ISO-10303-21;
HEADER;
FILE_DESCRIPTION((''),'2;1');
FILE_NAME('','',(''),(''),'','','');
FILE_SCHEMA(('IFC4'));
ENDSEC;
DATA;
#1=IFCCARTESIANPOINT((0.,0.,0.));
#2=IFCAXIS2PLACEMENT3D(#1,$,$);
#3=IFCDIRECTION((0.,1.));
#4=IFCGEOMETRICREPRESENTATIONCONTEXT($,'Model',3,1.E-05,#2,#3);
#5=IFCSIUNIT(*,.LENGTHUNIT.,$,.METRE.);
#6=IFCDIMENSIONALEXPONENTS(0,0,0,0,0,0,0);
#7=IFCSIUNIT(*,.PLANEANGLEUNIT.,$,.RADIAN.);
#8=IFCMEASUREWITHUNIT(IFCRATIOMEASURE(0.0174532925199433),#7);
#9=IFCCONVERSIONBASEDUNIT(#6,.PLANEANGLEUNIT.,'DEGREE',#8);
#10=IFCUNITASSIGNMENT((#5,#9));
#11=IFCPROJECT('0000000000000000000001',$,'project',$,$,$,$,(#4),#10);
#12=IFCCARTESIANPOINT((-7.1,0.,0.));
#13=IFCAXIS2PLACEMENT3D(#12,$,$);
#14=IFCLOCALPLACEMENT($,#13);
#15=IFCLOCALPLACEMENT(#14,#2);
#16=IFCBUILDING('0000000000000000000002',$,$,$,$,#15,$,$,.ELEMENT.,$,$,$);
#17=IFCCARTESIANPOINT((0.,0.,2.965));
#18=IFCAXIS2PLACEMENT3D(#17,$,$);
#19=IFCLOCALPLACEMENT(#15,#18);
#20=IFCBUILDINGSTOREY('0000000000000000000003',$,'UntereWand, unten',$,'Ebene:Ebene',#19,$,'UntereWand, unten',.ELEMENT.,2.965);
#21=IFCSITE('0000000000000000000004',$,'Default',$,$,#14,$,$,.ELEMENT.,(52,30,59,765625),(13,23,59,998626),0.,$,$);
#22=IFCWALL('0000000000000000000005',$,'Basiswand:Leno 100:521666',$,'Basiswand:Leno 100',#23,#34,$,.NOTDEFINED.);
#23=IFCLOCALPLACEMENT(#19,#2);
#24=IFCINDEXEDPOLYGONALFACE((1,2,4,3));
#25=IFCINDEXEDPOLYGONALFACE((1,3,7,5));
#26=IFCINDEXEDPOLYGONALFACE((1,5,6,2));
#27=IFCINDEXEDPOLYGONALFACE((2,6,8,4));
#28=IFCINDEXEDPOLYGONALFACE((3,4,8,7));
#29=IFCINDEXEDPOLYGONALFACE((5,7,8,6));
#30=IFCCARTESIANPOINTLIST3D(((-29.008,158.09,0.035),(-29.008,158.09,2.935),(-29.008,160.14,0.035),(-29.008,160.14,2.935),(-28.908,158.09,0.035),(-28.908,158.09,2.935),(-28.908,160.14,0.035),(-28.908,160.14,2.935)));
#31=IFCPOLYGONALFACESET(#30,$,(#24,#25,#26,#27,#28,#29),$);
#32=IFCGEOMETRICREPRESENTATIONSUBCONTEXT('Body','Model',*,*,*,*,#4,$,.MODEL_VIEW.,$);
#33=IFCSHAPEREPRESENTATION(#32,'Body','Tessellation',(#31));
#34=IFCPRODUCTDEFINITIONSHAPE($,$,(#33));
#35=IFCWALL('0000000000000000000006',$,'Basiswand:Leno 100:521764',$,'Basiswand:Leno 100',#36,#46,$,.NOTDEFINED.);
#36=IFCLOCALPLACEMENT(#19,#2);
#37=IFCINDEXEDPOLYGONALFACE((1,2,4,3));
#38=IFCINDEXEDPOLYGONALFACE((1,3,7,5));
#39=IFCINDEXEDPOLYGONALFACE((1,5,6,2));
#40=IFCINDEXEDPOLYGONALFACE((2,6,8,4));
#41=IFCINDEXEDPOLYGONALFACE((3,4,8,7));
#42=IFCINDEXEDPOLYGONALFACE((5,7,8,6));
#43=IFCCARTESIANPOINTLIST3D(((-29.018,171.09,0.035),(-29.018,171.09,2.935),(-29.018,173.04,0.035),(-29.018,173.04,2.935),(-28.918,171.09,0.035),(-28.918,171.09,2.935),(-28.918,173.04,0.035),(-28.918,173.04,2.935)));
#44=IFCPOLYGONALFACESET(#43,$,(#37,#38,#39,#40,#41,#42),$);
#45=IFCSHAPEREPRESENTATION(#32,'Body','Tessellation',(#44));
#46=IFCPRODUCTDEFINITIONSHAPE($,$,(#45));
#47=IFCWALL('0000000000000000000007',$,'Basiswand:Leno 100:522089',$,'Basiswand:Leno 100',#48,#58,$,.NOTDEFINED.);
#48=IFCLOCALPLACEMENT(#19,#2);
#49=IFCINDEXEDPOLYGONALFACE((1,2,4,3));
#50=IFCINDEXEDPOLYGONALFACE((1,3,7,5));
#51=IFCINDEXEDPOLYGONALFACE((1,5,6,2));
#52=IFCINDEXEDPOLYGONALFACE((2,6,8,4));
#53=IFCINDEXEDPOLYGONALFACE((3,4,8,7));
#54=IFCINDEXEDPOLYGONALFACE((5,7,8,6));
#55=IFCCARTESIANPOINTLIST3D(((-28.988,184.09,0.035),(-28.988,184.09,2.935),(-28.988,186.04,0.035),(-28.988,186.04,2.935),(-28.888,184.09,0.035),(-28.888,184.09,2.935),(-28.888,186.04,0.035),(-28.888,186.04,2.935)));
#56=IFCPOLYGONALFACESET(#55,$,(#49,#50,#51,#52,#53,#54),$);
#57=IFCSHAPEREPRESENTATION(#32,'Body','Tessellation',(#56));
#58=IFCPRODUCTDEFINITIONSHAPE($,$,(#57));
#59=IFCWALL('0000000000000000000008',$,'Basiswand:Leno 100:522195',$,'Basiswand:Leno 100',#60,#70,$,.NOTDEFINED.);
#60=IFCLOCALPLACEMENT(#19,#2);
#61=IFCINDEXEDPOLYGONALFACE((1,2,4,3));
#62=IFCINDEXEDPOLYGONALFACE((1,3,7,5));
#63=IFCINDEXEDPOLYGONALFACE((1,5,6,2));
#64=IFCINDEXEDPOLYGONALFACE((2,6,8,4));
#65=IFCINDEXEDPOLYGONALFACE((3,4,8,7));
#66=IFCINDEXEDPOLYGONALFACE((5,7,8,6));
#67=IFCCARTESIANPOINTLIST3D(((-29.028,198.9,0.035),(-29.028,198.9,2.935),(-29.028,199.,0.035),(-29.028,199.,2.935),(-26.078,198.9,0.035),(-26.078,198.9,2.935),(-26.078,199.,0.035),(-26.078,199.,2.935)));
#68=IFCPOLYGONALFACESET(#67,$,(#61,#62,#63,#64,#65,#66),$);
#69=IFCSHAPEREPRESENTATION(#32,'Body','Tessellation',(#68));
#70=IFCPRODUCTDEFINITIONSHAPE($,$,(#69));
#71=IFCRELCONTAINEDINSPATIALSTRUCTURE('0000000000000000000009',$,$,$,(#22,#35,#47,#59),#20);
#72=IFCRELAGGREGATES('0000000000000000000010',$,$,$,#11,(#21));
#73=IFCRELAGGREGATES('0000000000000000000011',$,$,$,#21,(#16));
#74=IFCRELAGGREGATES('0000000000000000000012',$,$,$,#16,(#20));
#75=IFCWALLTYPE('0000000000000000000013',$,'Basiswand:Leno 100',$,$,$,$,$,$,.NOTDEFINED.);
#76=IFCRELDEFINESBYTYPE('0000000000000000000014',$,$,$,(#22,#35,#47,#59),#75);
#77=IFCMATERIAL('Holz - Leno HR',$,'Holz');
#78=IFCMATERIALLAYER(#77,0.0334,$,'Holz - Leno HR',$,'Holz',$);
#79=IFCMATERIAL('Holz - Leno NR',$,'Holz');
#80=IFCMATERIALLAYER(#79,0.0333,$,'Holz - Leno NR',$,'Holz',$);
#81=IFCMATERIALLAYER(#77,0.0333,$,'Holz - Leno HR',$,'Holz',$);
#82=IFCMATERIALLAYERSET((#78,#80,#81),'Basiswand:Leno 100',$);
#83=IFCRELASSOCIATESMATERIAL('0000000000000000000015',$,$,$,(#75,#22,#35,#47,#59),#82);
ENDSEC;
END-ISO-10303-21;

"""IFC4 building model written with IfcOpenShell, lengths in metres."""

from ifc_helpers import new_model, entity, si_unit, converted_unit, direction, frame, origin, place, context, subcontext, project, spatial, indexed_curve, outline, extrude, material, layer, layer_set, type_object, element, save


model = new_model("IFC4")

# Units and contexts
model_context = context("Model", 3, precision=1e-05, world=origin(), true_north=direction((0.0, 1.0)))
body_context = subcontext(model_context, "Body", "Model", "MODEL_VIEW")
ifc_project = project(units=[si_unit("LENGTHUNIT", "METRE"), converted_unit("PLANEANGLEUNIT", "DEGREE", entity("IfcRatioMeasure", 0.0174532925199433), si_unit("PLANEANGLEUNIT", "RADIAN"), dimensions=[0, 0, 0, 0, 0, 0, 0])], contexts=[model_context])

# Site, building, storey
site_placement = place(None, frame((-7.1, 0.0, 0.0)))
site = spatial("IfcSite", under=ifc_project, at=site_placement, Name="Default", CompositionType="ELEMENT", RefLatitude=(52, 30, 59, 765625), RefLongitude=(13, 23, 59, 998626), RefElevation=0.0)
building_placement = place(site_placement, origin())
building = spatial("IfcBuilding", under=site, at=building_placement, CompositionType="ELEMENT")
storey_placement = place(building_placement, frame((0.0, 0.0, 2.965)))
storey = spatial("IfcBuildingStorey", under=building, at=storey_placement, Name="UntereWand, unten", ObjectType="Ebene:Ebene", LongName="UntereWand, unten", CompositionType="ELEMENT", Elevation=2.965)

# Shared definitions
ifc_material_1 = material(Name="Holz - Leno HR", Category="Holz")
ifc_layer_1 = layer(ifc_material_1, 0.0334, Name="Holz - Leno HR", Category="Holz")
ifc_material_2 = material(Name="Holz - Leno NR", Category="Holz")
ifc_layer_2 = layer(ifc_material_2, 0.0333, Name="Holz - Leno NR", Category="Holz")
ifc_layer_3 = layer(ifc_material_1, 0.0333, Name="Holz - Leno HR", Category="Holz")
ifc_layer_set = layer_set([ifc_layer_1, ifc_layer_2, ifc_layer_3], Name="Basiswand:Leno 100")
wall_type = type_object("IfcWallType", Name="Basiswand:Leno 100", PredefinedType="NOTDEFINED", material=ifc_layer_set)

# Walls
wall_1_placement = place(storey_placement, frame((-28.958, 158.09, 0.035), z_axis=(0.0, 0.0, 1.0), x_axis=(0.0, 1.0, 0.0)))
element("IfcWall", 1, at=wall_1_placement, inside=storey, type_object=wall_type, material=ifc_layer_set, Name="Basiswand:Leno 100:521666", ObjectType="Basiswand:Leno 100", PredefinedType="NOTDEFINED", context=body_context, shape_type="SweptSolid", body=[
    extrude(outline(indexed_curve([(2.05, 0.05), (0.0, 0.05), (0.0, -0.05), (2.05, -0.05), (2.05, 0.05)], self_intersect=False)), origin(), (0.0, 0.0, 1.0), 2.9),
])
wall_2_placement = place(storey_placement, frame((-28.968, 171.09, 0.035), z_axis=(0.0, 0.0, 1.0), x_axis=(0.0, 1.0, 0.0)))
element("IfcWall", 2, at=wall_2_placement, inside=storey, type_object=wall_type, material=ifc_layer_set, Name="Basiswand:Leno 100:521764", ObjectType="Basiswand:Leno 100", PredefinedType="NOTDEFINED", context=body_context, shape_type="SweptSolid", body=[
    extrude(outline(indexed_curve([(1.95, 0.05), (0.0, 0.05), (0.0, -0.05), (1.95, -0.05), (1.95, 0.05)], self_intersect=False)), origin(), (0.0, 0.0, 1.0), 2.9),
])
wall_3_placement = place(storey_placement, frame((-28.938, 184.09, 0.035), z_axis=(0.0, 0.0, 1.0), x_axis=(0.0, 1.0, 0.0)))
element("IfcWall", 3, at=wall_3_placement, inside=storey, type_object=wall_type, material=ifc_layer_set, Name="Basiswand:Leno 100:522089", ObjectType="Basiswand:Leno 100", PredefinedType="NOTDEFINED", context=body_context, shape_type="SweptSolid", body=[
    extrude(outline(indexed_curve([(1.95, 0.05), (0.0, 0.05), (0.0, -0.05), (1.95, -0.05), (1.95, 0.05)], self_intersect=False)), origin(), (0.0, 0.0, 1.0), 2.9),
])
wall_4_placement = place(storey_placement, frame((-26.078, 198.95, 0.035), z_axis=(0.0, 0.0, 1.0), x_axis=(-1.0, 0.0, 0.0)))
element("IfcWall", 4, at=wall_4_placement, inside=storey, type_object=wall_type, material=ifc_layer_set, Name="Basiswand:Leno 100:522195", ObjectType="Basiswand:Leno 100", PredefinedType="NOTDEFINED", context=body_context, shape_type="SweptSolid", body=[
    extrude(outline(indexed_curve([(2.95, 0.05), (0.0, 0.05), (0.0, -0.05), (2.95, -0.05), (2.95, 0.05)], self_intersect=False)), origin(), (0.0, 0.0, 1.0), 2.9),
])

save(model, "model.ifc")
